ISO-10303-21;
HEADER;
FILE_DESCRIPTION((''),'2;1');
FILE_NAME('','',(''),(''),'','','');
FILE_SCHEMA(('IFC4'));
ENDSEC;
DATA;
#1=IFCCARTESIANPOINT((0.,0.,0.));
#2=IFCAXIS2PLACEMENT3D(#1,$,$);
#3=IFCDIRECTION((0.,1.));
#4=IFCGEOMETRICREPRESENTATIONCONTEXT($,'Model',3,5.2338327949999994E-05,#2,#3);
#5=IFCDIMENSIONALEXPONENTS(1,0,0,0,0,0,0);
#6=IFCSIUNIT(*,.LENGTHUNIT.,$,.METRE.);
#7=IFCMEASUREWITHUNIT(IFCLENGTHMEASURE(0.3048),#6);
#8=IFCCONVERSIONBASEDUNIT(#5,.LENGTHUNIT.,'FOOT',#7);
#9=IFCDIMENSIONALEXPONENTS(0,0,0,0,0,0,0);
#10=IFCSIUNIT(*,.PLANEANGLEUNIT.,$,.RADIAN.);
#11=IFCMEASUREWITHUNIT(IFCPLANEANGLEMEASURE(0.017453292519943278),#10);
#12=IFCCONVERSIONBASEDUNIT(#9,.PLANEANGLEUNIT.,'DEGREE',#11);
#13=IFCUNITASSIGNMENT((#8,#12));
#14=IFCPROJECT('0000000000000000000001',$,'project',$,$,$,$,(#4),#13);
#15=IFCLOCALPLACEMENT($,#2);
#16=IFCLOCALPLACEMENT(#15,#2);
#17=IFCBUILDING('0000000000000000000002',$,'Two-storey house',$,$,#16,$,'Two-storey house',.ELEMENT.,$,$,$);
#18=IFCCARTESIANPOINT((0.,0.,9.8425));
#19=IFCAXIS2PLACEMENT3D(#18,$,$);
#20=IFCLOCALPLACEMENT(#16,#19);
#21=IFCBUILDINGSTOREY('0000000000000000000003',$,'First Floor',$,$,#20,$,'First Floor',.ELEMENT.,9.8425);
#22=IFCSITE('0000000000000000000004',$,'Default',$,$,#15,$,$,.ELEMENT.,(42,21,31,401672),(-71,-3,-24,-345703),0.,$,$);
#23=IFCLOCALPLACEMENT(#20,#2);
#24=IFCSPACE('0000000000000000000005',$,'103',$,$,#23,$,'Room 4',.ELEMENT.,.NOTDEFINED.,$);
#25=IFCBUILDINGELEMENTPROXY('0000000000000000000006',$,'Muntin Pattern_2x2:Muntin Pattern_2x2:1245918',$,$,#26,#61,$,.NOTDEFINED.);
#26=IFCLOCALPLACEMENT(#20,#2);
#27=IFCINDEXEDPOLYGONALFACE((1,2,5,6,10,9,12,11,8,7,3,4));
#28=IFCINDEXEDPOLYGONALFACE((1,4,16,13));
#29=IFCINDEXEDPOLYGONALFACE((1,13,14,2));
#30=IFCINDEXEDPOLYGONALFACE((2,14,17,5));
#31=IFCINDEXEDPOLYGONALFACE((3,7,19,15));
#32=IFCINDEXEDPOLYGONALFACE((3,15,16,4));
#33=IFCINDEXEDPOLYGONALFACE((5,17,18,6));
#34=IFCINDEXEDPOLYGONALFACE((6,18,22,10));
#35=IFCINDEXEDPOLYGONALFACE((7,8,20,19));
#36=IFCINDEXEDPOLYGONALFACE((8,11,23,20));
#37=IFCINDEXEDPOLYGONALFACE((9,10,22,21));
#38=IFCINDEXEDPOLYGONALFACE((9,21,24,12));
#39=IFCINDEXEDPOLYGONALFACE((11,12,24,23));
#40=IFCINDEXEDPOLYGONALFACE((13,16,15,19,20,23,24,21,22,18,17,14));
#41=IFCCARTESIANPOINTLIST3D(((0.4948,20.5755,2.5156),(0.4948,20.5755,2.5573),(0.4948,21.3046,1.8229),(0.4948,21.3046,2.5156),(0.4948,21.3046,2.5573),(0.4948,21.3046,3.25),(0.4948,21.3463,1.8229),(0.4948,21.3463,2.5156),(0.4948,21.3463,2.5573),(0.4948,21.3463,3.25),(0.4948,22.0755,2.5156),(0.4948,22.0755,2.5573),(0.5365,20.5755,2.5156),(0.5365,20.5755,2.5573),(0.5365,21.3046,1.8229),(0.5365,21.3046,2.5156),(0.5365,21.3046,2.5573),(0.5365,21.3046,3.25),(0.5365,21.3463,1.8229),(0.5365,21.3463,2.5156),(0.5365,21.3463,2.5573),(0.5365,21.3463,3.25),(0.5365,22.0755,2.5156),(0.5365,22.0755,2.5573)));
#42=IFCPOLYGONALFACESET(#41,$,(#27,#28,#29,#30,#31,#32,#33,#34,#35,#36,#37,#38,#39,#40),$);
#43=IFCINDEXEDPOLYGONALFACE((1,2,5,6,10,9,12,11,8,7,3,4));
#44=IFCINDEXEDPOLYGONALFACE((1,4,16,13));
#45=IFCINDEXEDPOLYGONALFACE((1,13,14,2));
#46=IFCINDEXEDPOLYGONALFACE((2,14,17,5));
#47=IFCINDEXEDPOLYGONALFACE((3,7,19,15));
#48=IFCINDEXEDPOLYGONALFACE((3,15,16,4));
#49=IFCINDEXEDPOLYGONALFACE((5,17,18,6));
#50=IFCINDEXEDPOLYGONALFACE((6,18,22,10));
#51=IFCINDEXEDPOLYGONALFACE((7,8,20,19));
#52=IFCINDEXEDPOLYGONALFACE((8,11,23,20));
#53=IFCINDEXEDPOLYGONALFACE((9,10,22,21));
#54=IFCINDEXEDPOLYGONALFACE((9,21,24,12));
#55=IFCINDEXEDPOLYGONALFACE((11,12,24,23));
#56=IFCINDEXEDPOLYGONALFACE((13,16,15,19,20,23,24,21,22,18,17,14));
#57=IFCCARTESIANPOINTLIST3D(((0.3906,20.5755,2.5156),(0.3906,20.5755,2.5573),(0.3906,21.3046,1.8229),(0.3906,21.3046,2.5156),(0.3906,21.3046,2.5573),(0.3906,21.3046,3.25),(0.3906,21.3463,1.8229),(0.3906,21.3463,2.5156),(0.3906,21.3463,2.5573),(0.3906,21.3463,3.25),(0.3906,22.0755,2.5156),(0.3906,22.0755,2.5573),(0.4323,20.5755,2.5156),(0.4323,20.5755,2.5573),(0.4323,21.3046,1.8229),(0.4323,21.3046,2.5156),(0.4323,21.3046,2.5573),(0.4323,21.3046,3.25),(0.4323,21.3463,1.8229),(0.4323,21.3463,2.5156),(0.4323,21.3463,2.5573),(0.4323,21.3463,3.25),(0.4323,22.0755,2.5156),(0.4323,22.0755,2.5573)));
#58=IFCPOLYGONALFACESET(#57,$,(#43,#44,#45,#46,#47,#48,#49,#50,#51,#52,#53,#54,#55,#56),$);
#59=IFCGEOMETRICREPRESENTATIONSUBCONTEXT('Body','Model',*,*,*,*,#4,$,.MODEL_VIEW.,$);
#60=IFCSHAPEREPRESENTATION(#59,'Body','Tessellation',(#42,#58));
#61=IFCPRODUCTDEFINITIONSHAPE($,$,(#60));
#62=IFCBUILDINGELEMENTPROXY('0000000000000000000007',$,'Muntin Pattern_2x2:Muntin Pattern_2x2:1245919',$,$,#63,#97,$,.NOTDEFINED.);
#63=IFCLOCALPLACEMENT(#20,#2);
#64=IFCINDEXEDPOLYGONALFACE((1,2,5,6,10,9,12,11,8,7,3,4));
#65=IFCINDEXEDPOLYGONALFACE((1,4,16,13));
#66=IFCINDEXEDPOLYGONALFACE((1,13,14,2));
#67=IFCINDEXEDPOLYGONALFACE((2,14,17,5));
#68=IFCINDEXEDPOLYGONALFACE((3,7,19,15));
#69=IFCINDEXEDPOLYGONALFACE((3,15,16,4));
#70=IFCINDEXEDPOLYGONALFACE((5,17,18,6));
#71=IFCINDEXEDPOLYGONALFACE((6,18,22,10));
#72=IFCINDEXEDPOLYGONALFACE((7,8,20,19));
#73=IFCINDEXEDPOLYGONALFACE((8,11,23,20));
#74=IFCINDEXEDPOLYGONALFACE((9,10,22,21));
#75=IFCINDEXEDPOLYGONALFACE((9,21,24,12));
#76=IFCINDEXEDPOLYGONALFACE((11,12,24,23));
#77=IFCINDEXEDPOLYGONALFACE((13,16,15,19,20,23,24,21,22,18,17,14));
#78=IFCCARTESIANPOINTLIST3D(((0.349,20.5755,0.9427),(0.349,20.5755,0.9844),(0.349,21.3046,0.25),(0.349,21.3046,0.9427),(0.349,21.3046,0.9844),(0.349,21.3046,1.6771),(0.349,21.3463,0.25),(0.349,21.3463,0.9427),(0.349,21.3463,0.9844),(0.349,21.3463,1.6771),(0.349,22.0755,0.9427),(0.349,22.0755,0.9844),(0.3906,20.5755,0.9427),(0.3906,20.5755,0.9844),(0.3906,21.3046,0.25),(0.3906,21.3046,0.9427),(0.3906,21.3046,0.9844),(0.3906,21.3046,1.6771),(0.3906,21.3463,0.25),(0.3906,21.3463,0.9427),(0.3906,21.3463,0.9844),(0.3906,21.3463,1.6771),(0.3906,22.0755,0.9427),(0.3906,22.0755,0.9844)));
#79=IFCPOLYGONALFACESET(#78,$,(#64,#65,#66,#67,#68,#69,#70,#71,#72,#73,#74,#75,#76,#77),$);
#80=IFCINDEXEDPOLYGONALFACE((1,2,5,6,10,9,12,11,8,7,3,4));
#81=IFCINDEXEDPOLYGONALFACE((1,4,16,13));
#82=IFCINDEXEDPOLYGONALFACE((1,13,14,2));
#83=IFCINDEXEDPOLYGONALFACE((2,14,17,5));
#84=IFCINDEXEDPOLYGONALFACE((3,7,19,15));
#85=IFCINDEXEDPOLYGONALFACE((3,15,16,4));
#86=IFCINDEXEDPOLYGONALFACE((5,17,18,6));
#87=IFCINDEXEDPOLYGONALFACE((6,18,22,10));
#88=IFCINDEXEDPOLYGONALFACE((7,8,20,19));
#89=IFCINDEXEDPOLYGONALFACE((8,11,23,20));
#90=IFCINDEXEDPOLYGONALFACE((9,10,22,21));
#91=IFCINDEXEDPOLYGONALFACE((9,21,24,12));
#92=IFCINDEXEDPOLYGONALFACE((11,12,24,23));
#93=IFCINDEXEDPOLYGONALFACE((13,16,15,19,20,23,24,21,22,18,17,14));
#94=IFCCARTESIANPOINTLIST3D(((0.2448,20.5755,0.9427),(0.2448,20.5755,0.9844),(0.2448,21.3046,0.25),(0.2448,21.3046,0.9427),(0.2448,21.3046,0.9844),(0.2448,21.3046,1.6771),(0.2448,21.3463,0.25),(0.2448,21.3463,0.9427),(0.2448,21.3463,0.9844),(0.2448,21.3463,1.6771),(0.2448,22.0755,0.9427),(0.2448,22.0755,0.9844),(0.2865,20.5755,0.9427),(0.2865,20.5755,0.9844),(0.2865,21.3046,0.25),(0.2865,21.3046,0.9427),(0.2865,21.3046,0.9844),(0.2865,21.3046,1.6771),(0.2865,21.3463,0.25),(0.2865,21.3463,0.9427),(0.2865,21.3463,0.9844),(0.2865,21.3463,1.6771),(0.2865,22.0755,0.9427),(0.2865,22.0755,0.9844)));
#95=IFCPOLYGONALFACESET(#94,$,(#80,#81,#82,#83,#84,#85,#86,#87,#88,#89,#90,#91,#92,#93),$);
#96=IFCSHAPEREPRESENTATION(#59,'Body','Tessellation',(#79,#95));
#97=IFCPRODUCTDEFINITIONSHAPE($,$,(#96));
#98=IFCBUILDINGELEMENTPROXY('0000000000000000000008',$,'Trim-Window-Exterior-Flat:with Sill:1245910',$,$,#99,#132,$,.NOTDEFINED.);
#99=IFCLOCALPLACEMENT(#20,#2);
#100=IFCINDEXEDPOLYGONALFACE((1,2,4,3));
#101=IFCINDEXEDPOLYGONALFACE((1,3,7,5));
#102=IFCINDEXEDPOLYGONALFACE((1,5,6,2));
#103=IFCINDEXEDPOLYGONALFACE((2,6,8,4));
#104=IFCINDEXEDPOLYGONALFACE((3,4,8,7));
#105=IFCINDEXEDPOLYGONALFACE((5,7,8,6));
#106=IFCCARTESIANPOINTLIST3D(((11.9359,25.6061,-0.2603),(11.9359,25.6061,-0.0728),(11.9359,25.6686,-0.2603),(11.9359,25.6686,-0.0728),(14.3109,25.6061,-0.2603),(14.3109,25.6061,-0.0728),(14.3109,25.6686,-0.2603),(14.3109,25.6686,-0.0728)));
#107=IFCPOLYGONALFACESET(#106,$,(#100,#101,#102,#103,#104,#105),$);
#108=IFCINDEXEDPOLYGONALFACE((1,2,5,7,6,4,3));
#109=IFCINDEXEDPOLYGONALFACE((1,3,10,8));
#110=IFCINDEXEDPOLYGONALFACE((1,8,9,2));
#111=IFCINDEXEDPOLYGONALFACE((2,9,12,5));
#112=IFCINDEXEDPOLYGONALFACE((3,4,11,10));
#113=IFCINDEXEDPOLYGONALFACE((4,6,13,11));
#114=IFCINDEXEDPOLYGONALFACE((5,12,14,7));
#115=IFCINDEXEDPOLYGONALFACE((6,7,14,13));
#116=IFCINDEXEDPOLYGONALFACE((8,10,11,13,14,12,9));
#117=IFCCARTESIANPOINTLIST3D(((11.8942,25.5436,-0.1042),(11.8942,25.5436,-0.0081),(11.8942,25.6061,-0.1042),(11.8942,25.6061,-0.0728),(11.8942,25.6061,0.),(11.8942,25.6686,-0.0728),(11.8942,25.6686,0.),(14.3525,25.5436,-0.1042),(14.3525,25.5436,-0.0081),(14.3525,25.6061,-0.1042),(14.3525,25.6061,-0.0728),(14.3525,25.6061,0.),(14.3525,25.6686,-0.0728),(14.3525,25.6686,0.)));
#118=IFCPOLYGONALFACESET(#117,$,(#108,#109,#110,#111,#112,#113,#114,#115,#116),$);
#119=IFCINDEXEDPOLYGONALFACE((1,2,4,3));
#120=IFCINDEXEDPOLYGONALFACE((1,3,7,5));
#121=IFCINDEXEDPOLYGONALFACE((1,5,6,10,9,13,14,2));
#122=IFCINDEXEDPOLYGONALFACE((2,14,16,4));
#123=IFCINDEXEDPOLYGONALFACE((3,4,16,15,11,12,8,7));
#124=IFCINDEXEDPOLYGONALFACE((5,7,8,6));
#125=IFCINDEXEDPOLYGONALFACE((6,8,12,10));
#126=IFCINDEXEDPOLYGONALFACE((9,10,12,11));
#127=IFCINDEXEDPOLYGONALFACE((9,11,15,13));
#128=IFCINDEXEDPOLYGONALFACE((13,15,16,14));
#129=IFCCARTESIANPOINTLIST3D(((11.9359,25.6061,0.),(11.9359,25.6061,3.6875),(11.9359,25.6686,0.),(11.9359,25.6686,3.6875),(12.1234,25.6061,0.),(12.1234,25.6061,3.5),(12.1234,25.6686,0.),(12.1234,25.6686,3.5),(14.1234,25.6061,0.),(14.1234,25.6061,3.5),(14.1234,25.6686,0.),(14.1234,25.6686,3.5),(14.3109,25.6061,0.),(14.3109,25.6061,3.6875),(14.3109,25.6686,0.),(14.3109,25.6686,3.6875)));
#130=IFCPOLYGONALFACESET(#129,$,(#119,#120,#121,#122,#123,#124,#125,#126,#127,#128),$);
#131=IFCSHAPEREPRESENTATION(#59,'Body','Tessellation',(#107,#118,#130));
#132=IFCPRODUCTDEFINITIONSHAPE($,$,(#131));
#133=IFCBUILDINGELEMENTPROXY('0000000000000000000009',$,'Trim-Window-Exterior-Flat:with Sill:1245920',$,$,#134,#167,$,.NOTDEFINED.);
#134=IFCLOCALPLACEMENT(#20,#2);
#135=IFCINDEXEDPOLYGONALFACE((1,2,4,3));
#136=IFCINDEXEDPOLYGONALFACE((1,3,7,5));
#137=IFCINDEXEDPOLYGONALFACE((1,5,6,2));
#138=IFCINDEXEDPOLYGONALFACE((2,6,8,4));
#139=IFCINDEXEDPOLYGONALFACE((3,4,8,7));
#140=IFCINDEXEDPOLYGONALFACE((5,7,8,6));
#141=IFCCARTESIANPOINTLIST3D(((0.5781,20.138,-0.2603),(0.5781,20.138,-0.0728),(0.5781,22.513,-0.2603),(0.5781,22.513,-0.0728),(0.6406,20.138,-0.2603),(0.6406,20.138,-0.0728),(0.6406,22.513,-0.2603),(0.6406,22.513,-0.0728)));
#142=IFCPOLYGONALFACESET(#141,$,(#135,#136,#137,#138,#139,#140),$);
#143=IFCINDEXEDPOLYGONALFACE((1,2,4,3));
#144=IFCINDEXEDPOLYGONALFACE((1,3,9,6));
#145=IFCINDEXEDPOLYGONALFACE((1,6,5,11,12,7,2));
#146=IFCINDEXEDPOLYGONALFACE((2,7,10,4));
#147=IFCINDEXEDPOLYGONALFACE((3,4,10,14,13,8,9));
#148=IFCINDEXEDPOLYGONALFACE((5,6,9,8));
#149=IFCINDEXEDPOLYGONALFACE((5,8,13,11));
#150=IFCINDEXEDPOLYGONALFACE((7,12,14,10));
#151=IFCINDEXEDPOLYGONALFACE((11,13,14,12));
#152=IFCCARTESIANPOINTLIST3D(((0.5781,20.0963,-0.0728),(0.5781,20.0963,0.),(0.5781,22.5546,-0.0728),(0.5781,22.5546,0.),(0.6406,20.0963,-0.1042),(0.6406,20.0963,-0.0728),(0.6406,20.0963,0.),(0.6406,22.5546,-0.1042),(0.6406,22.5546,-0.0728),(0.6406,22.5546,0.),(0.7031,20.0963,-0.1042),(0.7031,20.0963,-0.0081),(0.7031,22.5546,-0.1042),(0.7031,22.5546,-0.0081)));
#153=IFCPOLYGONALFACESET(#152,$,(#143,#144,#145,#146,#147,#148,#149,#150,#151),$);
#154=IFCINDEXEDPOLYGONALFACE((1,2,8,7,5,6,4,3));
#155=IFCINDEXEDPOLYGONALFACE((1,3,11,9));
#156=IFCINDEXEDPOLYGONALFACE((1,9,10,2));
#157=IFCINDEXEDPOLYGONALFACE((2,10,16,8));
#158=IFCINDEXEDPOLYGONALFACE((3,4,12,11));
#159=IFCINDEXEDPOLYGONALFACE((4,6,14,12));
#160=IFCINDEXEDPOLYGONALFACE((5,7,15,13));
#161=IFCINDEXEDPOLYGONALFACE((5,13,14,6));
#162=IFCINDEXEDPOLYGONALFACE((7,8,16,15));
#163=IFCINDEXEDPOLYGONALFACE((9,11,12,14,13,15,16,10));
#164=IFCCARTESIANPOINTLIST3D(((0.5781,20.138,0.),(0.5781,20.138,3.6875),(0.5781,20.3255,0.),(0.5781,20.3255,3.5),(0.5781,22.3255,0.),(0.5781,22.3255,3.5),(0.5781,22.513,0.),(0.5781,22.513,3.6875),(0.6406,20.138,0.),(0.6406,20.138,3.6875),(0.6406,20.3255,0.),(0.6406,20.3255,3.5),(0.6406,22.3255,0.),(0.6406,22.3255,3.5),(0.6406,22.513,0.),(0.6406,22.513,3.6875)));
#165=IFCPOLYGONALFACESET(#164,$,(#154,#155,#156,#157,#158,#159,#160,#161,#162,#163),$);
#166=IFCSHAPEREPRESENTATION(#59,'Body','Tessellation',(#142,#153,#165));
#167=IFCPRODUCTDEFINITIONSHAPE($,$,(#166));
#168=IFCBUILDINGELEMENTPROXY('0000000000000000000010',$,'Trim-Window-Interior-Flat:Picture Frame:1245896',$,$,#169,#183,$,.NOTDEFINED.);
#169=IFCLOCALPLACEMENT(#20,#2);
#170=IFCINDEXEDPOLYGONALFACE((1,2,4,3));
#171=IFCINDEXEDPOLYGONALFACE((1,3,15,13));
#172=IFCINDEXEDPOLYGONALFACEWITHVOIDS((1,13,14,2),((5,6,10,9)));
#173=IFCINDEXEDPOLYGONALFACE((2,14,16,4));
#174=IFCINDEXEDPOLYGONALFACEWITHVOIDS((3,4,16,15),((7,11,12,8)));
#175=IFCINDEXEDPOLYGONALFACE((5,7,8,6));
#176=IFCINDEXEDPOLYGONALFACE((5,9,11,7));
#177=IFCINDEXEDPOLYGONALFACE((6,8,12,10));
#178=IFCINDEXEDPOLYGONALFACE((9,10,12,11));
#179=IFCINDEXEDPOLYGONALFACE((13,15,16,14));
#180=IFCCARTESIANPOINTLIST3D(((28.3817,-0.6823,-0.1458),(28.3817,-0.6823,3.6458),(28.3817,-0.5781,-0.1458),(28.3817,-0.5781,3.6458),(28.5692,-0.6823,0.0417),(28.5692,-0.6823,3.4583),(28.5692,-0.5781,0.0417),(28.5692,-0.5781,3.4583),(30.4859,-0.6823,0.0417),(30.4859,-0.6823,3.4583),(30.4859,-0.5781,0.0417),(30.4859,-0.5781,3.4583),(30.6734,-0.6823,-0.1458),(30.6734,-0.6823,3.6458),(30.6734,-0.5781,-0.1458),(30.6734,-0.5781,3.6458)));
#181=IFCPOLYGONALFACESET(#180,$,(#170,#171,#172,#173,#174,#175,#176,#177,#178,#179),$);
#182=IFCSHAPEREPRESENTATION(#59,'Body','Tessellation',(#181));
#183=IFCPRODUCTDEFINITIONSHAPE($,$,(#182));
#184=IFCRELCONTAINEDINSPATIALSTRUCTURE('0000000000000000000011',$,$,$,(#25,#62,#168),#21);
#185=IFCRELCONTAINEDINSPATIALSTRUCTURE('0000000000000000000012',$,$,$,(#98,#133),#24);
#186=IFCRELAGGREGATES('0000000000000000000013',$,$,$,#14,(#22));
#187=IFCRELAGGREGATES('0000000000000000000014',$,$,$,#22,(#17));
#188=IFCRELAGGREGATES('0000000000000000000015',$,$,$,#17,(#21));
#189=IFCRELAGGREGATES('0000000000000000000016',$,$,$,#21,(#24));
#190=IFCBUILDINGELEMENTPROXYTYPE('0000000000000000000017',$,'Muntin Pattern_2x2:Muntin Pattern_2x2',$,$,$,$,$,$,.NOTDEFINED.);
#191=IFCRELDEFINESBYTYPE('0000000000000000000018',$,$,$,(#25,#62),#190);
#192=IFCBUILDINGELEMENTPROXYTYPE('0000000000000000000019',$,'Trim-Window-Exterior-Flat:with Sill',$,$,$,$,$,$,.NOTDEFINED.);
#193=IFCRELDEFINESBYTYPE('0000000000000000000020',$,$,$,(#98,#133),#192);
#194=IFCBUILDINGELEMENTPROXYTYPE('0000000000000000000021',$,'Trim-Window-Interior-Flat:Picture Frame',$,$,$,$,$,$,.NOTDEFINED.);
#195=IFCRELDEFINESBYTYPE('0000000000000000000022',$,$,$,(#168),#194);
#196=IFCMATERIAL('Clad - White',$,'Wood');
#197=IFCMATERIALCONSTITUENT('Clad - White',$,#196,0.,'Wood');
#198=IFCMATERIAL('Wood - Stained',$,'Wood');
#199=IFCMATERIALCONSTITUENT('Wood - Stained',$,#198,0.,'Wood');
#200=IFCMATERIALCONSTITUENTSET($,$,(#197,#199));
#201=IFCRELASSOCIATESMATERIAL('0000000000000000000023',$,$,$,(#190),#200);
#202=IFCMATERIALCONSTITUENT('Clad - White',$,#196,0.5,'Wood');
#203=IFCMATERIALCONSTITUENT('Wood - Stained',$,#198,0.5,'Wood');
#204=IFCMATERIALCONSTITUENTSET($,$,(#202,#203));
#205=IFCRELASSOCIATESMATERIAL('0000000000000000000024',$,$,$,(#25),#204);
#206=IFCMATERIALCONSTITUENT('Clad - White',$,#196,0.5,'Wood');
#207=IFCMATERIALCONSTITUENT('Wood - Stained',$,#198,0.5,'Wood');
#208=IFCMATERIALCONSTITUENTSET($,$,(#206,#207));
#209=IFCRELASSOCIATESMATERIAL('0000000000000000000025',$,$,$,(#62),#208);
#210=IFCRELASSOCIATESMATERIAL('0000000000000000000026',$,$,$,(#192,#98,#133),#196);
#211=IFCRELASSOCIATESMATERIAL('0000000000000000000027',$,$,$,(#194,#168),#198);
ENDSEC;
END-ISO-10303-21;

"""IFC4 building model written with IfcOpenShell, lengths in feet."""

from ifc_helpers import new_model, entity, si_unit, converted_unit, direction, frame, origin, place, context, subcontext, project, spatial, indexed_curve, outline, extrude, source, transform, mapped, material, constituent, constituent_set, type_object, type_shapes, element, save


model = new_model("IFC4")

# Units and contexts
model_context = context("Model", 3, precision=5.2338327949999994e-05, world=origin(), true_north=direction((0.0, 1.0)))
body_context = subcontext(model_context, "Body", "Model", "MODEL_VIEW")
ifc_project = project(units=[converted_unit("LENGTHUNIT", "FOOT", entity("IfcLengthMeasure", 0.3048), si_unit("LENGTHUNIT", "METRE"), dimensions=[1, 0, 0, 0, 0, 0, 0]), converted_unit("PLANEANGLEUNIT", "DEGREE", entity("IfcPlaneAngleMeasure", 0.017453292519943278), si_unit("PLANEANGLEUNIT", "RADIAN"), dimensions=[0, 0, 0, 0, 0, 0, 0])], contexts=[model_context])

# Site, building, storey
site_placement = place(None, origin())
site = spatial("IfcSite", under=ifc_project, at=site_placement, Name="Default", CompositionType="ELEMENT", RefLatitude=(42, 21, 31, 401672), RefLongitude=(-71, -3, -24, -345703), RefElevation=0.0)
building_placement = place(site_placement, origin())
building = spatial("IfcBuilding", under=site, at=building_placement, Name="Two-storey house", LongName="Two-storey house", CompositionType="ELEMENT")
storey_placement = place(building_placement, frame((0.0, 0.0, 9.8425)))
storey = spatial("IfcBuildingStorey", under=building, at=storey_placement, Name="First Floor", LongName="First Floor", CompositionType="ELEMENT", Elevation=9.8425)

# Shared definitions
ifc_material_1 = material(Name="Wood - Stained", Category="Wood")

# Building element proxies
ifc_material_2 = material(Name="Clad - White", Category="Wood")
ifc_constituent_1 = constituent(ifc_material_2, Name="Clad - White", Category="Wood", fraction=0.0)
ifc_constituent_2 = constituent(ifc_material_1, Name="Wood - Stained", Category="Wood", fraction=0.0)
ifc_constituent_set_1 = constituent_set(constituents=[ifc_constituent_1, ifc_constituent_2])
building_element_proxy_type_1 = type_object("IfcBuildingElementProxyType", Name="Muntin Pattern_2x2:Muntin Pattern_2x2", PredefinedType="NOTDEFINED", material=ifc_constituent_set_1)
shared_shape_1 = source(origin(), body_context, "Body", "SweptSolid", [
    extrude(outline(indexed_curve([(0.0208, -0.0208), (0.7135, -0.0208), (0.7135, 0.0208), (0.0208, 0.0208), (0.0208, 0.75), (-0.0208, 0.75), (-0.0208, 0.0208), (-0.7135, 0.0208), (-0.7135, -0.0208), (-0.0208, -0.0208), (-0.0208, -0.75), (0.0208, -0.75), (0.0208, -0.0208)], self_intersect=False)), frame((0.0, 0.0312, 0.7135), z_axis=(0.0, 1.0, 0.0), x_axis=(0.0, 0.0, 1.0)), (0.0, 0.0, 1.0), 0.0417),
    extrude(outline(indexed_curve([(0.0208, -0.0208), (0.7135, -0.0208), (0.7135, 0.0208), (0.0208, 0.0208), (0.0208, 0.75), (-0.0208, 0.75), (-0.0208, 0.0208), (-0.7135, 0.0208), (-0.7135, -0.0208), (-0.0208, -0.0208), (-0.0208, -0.75), (0.0208, -0.75), (0.0208, -0.0208)], self_intersect=False)), frame((0.0, -0.0729, 0.7135), z_axis=(0.0, 1.0, 0.0), x_axis=(0.0, 0.0, 1.0)), (0.0, 0.0, 1.0), 0.0417),
])
type_shapes(building_element_proxy_type_1, [shared_shape_1])
ifc_constituent_3 = constituent(ifc_material_2, Name="Clad - White", Category="Wood", fraction=0.5)
ifc_constituent_4 = constituent(ifc_material_1, Name="Wood - Stained", Category="Wood", fraction=0.5)
ifc_constituent_set_2 = constituent_set(constituents=[ifc_constituent_3, ifc_constituent_4])
proxy_1_placement = place(storey_placement, frame((0.4635, 21.3255, 1.8229), z_axis=(0.0, 0.0, 1.0), x_axis=(0.0, -1.0, 0.0)))
element("IfcBuildingElementProxy", 1, at=proxy_1_placement, inside=storey, type_object=building_element_proxy_type_1, material=ifc_constituent_set_2, Name="Muntin Pattern_2x2:Muntin Pattern_2x2:1245918", PredefinedType="NOTDEFINED", context=body_context, shape_type="MappedRepresentation", body=[
    mapped(shared_shape_1, transform((0.0, 0.0, 0.0), scale=1.0)),
])
ifc_constituent_5 = constituent(ifc_material_2, Name="Clad - White", Category="Wood", fraction=0.5)
ifc_constituent_6 = constituent(ifc_material_1, Name="Wood - Stained", Category="Wood", fraction=0.5)
ifc_constituent_set_3 = constituent_set(constituents=[ifc_constituent_5, ifc_constituent_6])
proxy_2_placement = place(storey_placement, frame((0.3177, 21.3255, 0.25), z_axis=(0.0, 0.0, 1.0), x_axis=(0.0, -1.0, 0.0)))
element("IfcBuildingElementProxy", 2, at=proxy_2_placement, inside=storey, type_object=building_element_proxy_type_1, material=ifc_constituent_set_3, Name="Muntin Pattern_2x2:Muntin Pattern_2x2:1245919", PredefinedType="NOTDEFINED", context=body_context, shape_type="MappedRepresentation", body=[
    mapped(shared_shape_1, transform((0.0, 0.0, 0.0), scale=1.0)),
])

# Shared definitions
space_placement = place(storey_placement, origin())
space = spatial("IfcSpace", under=storey, at=space_placement, Name="103", LongName="Room 4", CompositionType="ELEMENT", PredefinedType="NOTDEFINED")

# Building element proxies
building_element_proxy_type_2 = type_object("IfcBuildingElementProxyType", Name="Trim-Window-Exterior-Flat:with Sill", PredefinedType="NOTDEFINED", material=ifc_material_2)
shared_shape_2 = source(origin(), body_context, "Body", "SweptSolid", [
    extrude(outline(indexed_curve([(-1.1875, -0.0938), (1.1875, -0.0938), (1.1875, 0.0938), (-1.1875, 0.0938), (-1.1875, -0.0938)], self_intersect=False)), frame((0.0, -3.6665, 0.0), z_axis=(0.0, 0.0, 1.0), x_axis=(-1.0, 0.0, 0.0)), (0.0, 0.0, 1.0), 0.0625),
    extrude(outline(indexed_curve([(-0.0625, -0.0525), (0.0, -0.0525), (0.0, -0.0211), (0.0625, -0.0211), (0.0625, 0.0517), (0.0, 0.0517), (-0.0625, 0.0436), (-0.0625, -0.0525)], self_intersect=False)), frame((-1.2292, -3.5517, 0.0625), z_axis=(1.0, 0.0, 0.0), x_axis=(0.0, 0.0, -1.0)), (0.0, 0.0, 1.0), 2.4583),
    extrude(outline(indexed_curve([(-1.8906, -1.1875), (1.7969, -1.1875), (1.7969, -1.0), (-1.7031, -1.0), (-1.7031, 1.0), (1.7969, 1.0), (1.7969, 1.1875), (-1.8906, 1.1875), (-1.8906, -1.1875)], self_intersect=False)), frame((0.0, -1.7031, 0.0), z_axis=(0.0, 0.0, 1.0), x_axis=(0.0, -1.0, 0.0)), (0.0, 0.0, 1.0), 0.0625),
])
type_shapes(building_element_proxy_type_2, [shared_shape_2])
for number, where, z_axis, x_axis, name in (
    (3, (13.1234, 25.6686, 3.5), (0.0, -1.0, 0.0), (1.0, 0.0, 0.0), "Trim-Window-Exterior-Flat:with Sill:1245910"),
    (4, (0.5781, 21.3255, 3.5), (1.0, 0.0, 0.0), (0.0, 1.0, 0.0), "Trim-Window-Exterior-Flat:with Sill:1245920"),
):
    element("IfcBuildingElementProxy", number, at=place(space_placement, frame(where, z_axis=z_axis, x_axis=x_axis)), inside=space, type_object=building_element_proxy_type_2, material=ifc_material_2, Name=name, PredefinedType="NOTDEFINED", context=body_context, shape_type="MappedRepresentation", body=[
        mapped(shared_shape_2, transform((0.0, 0.0, 0.0), scale=1.0)),
    ])
building_element_proxy_type_3 = type_object("IfcBuildingElementProxyType", Name="Trim-Window-Interior-Flat:Picture Frame", PredefinedType="NOTDEFINED", material=ifc_material_1)
shared_shape_3 = source(origin(), body_context, "Body", "SweptSolid", [
    extrude(outline(indexed_curve([(-1.1458, -1.8958), (1.1458, -1.8958), (1.1458, 1.8958), (-1.1458, 1.8958), (-1.1458, -1.8958)], self_intersect=False), holes=[indexed_curve([(-0.9583, -1.7083), (-0.9583, 1.7083), (0.9583, 1.7083), (0.9583, -1.7083), (-0.9583, -1.7083)], self_intersect=False)]), frame((0.0, -1.75, 0.0), z_axis=(0.0, 0.0, 1.0), x_axis=(-1.0, 0.0, 0.0)), (0.0, 0.0, 1.0), 0.1042),
])
type_shapes(building_element_proxy_type_3, [shared_shape_3])
for number, where, z_axis, x_axis, name in (
    (5, (29.5276, -0.5781, 3.5), (0.0, -1.0, 0.0), (1.0, 0.0, 0.0), "Trim-Window-Interior-Flat:Picture Frame:1245896"),
):
    element("IfcBuildingElementProxy", number, at=place(storey_placement, frame(where, z_axis=z_axis, x_axis=x_axis)), inside=storey, type_object=building_element_proxy_type_3, material=ifc_material_1, Name=name, PredefinedType="NOTDEFINED", context=body_context, shape_type="MappedRepresentation", body=[
        mapped(shared_shape_3, transform((0.0, 0.0, 0.0), scale=1.0)),
    ])

save(model, "model.ifc")
